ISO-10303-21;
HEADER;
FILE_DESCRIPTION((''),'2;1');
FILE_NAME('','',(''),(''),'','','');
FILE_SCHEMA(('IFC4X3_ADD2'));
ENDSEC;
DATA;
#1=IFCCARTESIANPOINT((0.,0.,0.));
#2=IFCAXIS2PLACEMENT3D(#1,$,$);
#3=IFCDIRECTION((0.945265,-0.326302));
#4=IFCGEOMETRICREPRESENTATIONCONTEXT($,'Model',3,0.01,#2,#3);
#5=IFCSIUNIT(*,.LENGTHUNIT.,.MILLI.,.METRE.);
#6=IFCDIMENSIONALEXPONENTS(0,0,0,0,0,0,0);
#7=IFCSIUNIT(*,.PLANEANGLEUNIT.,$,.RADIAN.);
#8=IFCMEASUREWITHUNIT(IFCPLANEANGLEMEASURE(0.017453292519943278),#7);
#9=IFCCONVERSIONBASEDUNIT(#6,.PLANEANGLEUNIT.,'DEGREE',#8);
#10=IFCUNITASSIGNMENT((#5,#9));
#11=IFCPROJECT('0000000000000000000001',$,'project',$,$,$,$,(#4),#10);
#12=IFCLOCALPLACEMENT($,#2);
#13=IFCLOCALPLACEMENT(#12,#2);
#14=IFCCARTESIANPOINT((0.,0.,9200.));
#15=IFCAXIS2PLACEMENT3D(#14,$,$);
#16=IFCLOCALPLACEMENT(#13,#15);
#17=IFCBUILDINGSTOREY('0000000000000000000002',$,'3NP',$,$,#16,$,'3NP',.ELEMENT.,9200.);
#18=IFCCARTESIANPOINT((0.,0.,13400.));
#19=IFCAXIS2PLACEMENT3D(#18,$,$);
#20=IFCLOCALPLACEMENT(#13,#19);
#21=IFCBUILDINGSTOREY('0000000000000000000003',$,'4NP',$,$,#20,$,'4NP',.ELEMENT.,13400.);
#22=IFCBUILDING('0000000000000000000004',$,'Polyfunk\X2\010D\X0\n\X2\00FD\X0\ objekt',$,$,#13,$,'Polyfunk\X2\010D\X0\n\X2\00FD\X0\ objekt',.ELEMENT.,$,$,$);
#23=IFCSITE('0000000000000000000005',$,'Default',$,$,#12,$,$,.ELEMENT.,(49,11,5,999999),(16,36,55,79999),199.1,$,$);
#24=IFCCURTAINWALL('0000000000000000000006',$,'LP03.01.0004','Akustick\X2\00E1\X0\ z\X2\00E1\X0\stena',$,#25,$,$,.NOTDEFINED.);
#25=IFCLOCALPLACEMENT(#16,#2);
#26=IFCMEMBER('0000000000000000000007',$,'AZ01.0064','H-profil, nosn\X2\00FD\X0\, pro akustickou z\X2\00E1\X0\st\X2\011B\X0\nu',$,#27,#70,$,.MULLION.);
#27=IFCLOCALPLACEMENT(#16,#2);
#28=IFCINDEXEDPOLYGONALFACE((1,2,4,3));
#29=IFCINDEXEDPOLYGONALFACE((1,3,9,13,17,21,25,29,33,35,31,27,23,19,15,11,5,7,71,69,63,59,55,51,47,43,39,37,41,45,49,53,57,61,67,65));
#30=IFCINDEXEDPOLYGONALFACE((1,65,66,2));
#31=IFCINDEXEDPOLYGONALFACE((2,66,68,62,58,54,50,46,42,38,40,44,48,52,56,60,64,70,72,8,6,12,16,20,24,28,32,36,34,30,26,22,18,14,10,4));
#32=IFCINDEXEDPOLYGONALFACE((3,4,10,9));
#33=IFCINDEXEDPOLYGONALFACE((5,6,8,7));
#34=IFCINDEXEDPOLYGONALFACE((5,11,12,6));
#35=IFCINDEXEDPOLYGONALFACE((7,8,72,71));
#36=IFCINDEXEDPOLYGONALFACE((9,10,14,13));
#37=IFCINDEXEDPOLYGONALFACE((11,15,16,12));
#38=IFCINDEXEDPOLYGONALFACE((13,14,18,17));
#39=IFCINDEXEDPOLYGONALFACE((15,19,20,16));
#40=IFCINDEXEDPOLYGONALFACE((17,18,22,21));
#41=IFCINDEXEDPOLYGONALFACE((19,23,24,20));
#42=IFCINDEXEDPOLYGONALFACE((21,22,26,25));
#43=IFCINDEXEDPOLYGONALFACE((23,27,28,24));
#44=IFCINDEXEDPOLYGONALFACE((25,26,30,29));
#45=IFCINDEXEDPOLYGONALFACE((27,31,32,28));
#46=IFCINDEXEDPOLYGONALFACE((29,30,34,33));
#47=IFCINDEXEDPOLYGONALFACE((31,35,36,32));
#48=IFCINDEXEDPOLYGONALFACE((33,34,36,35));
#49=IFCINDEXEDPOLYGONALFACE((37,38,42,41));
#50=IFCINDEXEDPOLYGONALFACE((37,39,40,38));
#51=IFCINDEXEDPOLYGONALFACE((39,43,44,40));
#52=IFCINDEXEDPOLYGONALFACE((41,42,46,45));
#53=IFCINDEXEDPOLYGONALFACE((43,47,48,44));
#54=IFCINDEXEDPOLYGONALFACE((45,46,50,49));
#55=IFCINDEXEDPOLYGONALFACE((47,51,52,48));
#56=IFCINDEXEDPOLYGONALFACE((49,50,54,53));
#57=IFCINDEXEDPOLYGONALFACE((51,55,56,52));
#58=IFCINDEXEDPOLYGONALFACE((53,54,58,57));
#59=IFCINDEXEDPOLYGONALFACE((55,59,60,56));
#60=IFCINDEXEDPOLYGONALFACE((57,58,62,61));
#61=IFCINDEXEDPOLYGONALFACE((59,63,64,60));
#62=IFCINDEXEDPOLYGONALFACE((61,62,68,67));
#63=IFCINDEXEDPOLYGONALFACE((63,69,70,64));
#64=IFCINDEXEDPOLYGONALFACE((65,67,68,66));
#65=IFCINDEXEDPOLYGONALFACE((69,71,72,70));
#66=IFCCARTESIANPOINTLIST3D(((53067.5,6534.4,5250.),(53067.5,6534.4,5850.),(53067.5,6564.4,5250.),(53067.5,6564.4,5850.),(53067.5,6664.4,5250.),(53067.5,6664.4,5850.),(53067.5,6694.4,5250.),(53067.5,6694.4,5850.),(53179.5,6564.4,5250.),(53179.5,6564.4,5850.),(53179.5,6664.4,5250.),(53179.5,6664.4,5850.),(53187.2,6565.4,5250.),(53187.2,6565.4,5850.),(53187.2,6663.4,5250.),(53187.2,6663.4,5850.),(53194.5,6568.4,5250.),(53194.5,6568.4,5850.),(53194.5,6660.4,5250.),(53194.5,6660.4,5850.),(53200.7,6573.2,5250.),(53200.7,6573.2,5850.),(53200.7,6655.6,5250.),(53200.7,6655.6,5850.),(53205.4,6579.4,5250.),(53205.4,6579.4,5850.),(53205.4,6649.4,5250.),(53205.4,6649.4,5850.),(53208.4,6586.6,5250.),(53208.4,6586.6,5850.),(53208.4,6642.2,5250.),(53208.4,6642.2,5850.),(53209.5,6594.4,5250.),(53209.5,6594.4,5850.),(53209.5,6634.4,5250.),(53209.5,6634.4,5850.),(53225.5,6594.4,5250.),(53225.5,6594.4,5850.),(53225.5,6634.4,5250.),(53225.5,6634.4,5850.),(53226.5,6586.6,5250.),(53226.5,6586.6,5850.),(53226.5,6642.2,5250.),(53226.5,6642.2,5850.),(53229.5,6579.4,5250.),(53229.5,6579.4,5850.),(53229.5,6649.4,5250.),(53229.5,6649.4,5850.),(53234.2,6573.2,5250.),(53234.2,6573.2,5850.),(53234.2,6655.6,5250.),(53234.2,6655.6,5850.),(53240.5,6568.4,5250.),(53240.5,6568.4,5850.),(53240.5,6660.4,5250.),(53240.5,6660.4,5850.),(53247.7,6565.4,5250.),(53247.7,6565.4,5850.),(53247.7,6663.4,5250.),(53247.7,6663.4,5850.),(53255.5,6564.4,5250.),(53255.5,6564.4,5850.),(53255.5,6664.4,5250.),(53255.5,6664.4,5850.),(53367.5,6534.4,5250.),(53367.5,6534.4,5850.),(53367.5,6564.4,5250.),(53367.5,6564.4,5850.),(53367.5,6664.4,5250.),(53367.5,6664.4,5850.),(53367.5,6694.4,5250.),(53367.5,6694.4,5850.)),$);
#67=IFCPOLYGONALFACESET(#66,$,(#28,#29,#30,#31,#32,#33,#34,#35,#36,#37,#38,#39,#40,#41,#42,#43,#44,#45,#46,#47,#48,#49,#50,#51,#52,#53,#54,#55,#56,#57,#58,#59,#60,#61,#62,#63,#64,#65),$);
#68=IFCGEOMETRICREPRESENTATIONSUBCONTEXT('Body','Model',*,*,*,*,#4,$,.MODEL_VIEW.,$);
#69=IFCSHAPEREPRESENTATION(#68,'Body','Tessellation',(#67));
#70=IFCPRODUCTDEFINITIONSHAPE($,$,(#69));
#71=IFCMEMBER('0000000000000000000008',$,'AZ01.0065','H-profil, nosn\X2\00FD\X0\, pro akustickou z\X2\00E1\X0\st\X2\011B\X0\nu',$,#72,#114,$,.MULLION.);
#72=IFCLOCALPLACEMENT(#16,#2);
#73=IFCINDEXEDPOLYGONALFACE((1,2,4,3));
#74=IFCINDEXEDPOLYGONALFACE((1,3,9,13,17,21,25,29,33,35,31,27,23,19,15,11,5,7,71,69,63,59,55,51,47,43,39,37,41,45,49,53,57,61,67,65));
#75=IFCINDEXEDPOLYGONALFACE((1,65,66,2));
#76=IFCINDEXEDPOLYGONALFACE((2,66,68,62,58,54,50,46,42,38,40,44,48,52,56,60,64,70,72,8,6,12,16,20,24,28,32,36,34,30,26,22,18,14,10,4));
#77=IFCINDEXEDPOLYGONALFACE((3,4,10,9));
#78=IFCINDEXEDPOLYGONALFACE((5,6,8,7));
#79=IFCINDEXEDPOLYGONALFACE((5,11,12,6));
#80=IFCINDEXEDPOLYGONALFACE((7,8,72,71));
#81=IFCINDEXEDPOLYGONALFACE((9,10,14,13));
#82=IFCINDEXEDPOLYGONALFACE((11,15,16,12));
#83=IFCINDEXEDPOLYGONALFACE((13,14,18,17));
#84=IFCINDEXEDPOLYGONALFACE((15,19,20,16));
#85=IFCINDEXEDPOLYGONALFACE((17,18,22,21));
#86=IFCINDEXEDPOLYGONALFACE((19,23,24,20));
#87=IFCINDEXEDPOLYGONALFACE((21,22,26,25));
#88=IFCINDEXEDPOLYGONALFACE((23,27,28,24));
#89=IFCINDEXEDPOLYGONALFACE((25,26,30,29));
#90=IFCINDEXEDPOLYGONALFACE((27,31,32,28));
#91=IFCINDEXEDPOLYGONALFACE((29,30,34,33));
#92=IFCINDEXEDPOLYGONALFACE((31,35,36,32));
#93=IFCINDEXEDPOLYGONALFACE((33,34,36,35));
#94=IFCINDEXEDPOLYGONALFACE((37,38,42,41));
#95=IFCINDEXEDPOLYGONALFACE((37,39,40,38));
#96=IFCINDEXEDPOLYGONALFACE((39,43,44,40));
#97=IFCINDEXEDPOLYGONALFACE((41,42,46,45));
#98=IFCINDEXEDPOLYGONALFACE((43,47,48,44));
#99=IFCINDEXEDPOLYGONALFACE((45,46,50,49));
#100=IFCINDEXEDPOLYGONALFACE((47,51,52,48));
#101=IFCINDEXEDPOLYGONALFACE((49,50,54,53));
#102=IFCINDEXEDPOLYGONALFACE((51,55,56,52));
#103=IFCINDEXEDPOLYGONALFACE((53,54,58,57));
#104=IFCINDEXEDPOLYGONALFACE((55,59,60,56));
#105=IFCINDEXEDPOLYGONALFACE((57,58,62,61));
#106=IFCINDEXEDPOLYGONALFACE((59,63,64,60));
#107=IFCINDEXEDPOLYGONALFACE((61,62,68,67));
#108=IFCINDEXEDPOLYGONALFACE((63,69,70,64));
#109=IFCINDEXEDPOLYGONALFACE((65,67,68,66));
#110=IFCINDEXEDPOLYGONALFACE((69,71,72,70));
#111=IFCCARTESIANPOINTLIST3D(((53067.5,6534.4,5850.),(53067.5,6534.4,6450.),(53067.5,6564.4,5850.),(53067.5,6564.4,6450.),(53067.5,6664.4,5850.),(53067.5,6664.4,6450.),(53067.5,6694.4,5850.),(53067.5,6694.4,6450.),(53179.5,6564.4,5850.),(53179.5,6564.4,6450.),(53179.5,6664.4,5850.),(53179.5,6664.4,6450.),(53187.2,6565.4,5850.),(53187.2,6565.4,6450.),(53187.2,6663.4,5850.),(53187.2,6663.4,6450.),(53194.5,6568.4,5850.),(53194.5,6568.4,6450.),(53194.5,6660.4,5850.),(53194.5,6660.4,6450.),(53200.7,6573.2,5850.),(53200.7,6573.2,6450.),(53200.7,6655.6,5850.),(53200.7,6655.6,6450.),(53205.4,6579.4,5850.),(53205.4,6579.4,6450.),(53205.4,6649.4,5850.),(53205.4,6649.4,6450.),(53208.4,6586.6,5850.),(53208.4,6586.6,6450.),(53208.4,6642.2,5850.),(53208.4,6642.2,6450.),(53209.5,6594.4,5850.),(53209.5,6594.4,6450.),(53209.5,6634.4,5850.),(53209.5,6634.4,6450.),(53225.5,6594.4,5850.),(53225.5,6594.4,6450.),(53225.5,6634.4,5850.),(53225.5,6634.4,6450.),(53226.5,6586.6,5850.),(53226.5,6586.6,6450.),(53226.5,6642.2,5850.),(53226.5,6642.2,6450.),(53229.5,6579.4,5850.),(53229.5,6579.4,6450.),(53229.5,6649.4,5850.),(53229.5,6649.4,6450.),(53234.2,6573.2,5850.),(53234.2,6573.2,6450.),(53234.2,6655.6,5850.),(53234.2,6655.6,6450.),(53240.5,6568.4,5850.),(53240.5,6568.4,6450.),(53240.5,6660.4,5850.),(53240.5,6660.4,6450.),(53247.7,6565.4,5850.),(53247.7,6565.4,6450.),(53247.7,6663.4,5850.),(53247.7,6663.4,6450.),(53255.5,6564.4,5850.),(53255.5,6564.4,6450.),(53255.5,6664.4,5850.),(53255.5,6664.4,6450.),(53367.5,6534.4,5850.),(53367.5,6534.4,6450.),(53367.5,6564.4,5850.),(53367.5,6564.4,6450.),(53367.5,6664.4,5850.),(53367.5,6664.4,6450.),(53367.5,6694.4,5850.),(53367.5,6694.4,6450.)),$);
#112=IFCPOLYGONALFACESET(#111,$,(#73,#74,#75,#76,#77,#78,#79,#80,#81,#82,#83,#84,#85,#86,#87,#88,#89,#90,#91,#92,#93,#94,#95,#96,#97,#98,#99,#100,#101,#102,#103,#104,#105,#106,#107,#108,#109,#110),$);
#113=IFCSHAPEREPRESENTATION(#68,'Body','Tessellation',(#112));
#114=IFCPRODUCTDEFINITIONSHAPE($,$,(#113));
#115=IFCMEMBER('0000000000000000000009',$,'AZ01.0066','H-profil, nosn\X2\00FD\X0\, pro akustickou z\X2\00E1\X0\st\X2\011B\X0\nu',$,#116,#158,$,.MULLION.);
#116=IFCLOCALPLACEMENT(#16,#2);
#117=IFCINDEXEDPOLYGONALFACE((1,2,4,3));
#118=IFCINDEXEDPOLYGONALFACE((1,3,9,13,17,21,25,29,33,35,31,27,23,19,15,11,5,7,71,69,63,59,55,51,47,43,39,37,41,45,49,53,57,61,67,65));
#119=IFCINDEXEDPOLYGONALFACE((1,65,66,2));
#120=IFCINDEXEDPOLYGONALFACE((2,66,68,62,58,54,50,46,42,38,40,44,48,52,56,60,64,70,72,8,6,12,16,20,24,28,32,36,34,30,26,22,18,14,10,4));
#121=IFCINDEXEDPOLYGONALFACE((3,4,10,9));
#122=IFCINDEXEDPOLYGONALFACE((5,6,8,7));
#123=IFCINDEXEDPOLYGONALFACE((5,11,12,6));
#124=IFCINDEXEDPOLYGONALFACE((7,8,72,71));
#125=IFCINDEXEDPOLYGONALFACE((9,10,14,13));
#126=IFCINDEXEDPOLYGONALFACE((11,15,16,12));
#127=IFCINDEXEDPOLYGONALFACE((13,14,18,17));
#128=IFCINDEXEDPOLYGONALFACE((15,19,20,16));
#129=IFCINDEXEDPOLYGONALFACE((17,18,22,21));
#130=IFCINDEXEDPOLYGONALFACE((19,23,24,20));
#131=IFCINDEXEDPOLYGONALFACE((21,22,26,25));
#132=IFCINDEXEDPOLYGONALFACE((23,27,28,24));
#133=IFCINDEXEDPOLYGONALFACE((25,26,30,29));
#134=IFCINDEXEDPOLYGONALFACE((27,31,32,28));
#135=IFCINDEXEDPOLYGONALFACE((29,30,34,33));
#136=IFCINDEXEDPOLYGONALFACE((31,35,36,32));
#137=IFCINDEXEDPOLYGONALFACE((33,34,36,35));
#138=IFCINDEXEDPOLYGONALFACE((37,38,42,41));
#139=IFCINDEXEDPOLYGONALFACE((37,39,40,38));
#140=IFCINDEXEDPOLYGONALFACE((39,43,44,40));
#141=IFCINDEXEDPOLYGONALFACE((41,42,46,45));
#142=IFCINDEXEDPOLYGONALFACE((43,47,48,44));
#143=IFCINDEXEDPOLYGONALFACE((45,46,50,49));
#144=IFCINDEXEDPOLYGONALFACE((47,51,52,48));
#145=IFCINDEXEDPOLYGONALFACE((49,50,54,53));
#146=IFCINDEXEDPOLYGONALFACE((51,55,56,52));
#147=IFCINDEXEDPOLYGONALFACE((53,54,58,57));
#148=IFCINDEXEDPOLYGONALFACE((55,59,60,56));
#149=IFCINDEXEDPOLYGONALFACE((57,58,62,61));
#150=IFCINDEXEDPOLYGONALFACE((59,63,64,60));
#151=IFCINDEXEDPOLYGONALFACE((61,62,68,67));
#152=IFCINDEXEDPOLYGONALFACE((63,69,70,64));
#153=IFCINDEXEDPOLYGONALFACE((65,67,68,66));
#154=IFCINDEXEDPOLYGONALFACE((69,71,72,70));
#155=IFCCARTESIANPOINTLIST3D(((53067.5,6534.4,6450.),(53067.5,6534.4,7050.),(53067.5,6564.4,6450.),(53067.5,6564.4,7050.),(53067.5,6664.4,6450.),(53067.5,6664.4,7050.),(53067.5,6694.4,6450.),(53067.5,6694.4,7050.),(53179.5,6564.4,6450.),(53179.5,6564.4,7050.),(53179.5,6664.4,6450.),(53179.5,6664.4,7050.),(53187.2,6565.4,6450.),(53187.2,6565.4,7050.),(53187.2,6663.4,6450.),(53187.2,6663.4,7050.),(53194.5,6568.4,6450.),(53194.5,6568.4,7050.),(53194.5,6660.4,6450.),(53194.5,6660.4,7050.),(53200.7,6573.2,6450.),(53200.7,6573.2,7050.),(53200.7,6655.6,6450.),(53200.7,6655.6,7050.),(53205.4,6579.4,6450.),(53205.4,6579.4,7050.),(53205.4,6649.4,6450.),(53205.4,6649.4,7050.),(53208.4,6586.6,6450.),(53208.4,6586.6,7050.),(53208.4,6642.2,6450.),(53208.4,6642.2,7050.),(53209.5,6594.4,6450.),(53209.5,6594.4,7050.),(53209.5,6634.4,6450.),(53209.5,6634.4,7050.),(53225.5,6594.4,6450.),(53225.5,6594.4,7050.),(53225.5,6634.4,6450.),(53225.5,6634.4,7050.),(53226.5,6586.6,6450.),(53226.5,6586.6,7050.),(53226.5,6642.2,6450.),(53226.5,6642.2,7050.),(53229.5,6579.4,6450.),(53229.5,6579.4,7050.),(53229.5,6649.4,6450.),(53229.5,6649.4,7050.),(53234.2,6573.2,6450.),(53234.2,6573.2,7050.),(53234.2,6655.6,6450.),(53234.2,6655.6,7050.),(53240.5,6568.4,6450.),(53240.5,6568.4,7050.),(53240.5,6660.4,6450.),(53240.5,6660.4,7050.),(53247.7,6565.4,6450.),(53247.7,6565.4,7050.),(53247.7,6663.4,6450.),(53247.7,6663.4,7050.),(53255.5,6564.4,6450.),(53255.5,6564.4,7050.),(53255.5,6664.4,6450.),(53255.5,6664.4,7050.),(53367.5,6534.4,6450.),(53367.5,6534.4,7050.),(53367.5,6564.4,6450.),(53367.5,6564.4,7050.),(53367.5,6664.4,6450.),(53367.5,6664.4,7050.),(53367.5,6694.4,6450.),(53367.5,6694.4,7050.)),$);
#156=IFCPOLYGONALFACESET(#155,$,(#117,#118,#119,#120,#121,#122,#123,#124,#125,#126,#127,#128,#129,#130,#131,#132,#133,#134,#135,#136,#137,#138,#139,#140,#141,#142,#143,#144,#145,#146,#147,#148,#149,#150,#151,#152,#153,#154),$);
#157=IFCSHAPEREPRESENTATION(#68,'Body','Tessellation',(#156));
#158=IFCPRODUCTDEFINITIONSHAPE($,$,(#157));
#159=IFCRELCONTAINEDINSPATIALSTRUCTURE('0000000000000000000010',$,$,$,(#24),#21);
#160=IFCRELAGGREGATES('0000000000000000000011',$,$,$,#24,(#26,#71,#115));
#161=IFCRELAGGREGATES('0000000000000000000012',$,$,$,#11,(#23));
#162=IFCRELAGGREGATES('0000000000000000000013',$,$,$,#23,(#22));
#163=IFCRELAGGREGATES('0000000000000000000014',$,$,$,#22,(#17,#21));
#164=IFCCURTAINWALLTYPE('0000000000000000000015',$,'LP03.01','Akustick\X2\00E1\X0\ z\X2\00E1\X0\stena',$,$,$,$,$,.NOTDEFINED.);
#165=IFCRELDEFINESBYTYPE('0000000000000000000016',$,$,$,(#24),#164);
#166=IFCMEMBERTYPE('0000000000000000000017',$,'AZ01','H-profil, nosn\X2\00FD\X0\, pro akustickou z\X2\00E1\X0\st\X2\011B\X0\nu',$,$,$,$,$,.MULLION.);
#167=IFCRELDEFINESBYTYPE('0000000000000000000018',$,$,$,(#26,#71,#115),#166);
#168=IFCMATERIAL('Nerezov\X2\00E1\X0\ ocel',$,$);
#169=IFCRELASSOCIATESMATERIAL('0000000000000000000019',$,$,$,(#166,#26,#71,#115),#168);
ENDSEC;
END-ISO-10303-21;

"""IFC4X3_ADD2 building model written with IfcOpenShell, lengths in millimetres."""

from ifc_helpers import new_model, entity, si_unit, converted_unit, direction, frame, frame_2d, origin, place, context, subcontext, project, spatial, polyline, circle_curve, parameter, trimmed, segment, composite_curve, outline, extrude, source, transform, mapped, material, material_profile, profile_set, profile_usage, type_object, element, aggregate, save


model = new_model("IFC4X3_ADD2")

# Units and contexts
model_context = context("Model", 3, precision=0.01, world=origin(), true_north=direction((0.945265, -0.326302)))
body_context = subcontext(model_context, "Body", "Model", "MODEL_VIEW")
ifc_project = project(units=[si_unit("LENGTHUNIT", "METRE", prefix="MILLI"), converted_unit("PLANEANGLEUNIT", "DEGREE", entity("IfcPlaneAngleMeasure", 0.017453292519943278), si_unit("PLANEANGLEUNIT", "RADIAN"), dimensions=[0, 0, 0, 0, 0, 0, 0])], contexts=[model_context])

# Site, building, storey
site_placement = place(None, origin())
site = spatial("IfcSite", under=ifc_project, at=site_placement, Name="Default", CompositionType="ELEMENT", RefLatitude=(49, 11, 5, 999999), RefLongitude=(16, 36, 55, 79999), RefElevation=199.1)
building_placement = place(site_placement, origin())
building = spatial("IfcBuilding", under=site, at=building_placement, Name="Polyfunkčný objekt", LongName="Polyfunkčný objekt", CompositionType="ELEMENT")
storey_1_placement = place(building_placement, frame((0.0, 0.0, 9200.0)))
storey_1 = spatial("IfcBuildingStorey", under=building, at=storey_1_placement, Name="3NP", LongName="3NP", CompositionType="ELEMENT", Elevation=9200.0)

# Shared definitions
storey_2_placement = place(building_placement, frame((0.0, 0.0, 13400.0)))
storey_2 = spatial("IfcBuildingStorey", under=building, at=storey_2_placement, Name="4NP", LongName="4NP", CompositionType="ELEMENT", Elevation=13400.0)

# Curtain wall, members
curtain_wall_type_1 = type_object("IfcCurtainWallType", Name="LP03.01", Description="Akustická zástena", PredefinedType="NOTDEFINED")
curtain_wall_1_placement = place(storey_2_placement, frame((0.0, 0.0, -13400.0)))
curtain_wall_1 = element("IfcCurtainWall", 1, at=curtain_wall_1_placement, inside=storey_2, type_object=curtain_wall_type_1, Name="LP03.01.0004", Description="Akustická zástena", PredefinedType="NOTDEFINED")
ifc_material_1 = material(Name="Nerezová ocel")
ifc_material_profile_1 = material_profile(ifc_material_1, outline(composite_curve([segment(polyline([(50.0, -150.0), (80.0, -150.0)]), True, "CONTINUOUS"), segment(polyline([(80.0, -150.0), (80.0, 150.0)]), True, "CONTINUOUS"), segment(polyline([(80.0, 150.0), (50.0, 150.0)]), True, "CONTINUOUS"), segment(polyline([(50.0, 150.0), (50.0, 38.0)]), True, "CONTINUOUS"), segment(trimmed(circle_curve(frame_2d((20.0, 38.0), x_axis=(0.0, 1.0)), 30.0), [parameter(180.0)], [parameter(270.0)], True, "PARAMETER"), False, "CONTINUOUS"), segment(polyline([(20.0, 8.0), (-20.0, 8.0)]), True, "CONTINUOUS"), segment(trimmed(circle_curve(frame_2d((-20.0, 38.0), x_axis=(0.0, 1.0)), 30.0), [parameter(90.0)], [parameter(180.0)], True, "PARAMETER"), False, "CONTINUOUS"), segment(polyline([(-50.0, 38.0), (-50.0, 150.0)]), True, "CONTINUOUS"), segment(polyline([(-50.0, 150.0), (-80.0, 150.0)]), True, "CONTINUOUS"), segment(polyline([(-80.0, 150.0), (-80.0, -150.0)]), True, "CONTINUOUS"), segment(polyline([(-80.0, -150.0), (-50.0, -150.0)]), True, "CONTINUOUS"), segment(polyline([(-50.0, -150.0), (-50.0, -38.0)]), True, "CONTINUOUS"), segment(trimmed(circle_curve(frame_2d((-20.0, -38.0), x_axis=(0.0, 1.0)), 30.0), [parameter(0.0)], [parameter(90.0)], True, "PARAMETER"), False, "CONTINUOUS"), segment(polyline([(-20.0, -8.0), (20.0, -8.0)]), True, "CONTINUOUS"), segment(trimmed(circle_curve(frame_2d((20.0, -38.0), x_axis=(0.0, 1.0)), 30.0), [parameter(270.0)], [parameter(0.0)], True, "PARAMETER"), False, "CONTINUOUS"), segment(polyline([(50.0, -38.0), (50.0, -150.0)]), True, "CONTINUOUS")], self_intersect=False)), Name="Profil zástena")
ifc_profile_set_1 = profile_set([ifc_material_profile_1], Name="Profil zástena")
ifc_profile_usage_1 = profile_usage(ifc_profile_set_1)
member_type_1 = type_object("IfcMemberType", Name="AZ01", Description="H-profil, nosný, pro akustickou zástěnu", PredefinedType="MULLION", material=ifc_profile_set_1)
shared_shape_1 = source(origin(), body_context, "Body", "SweptSolid", [
    extrude(outline(composite_curve([segment(polyline([(50.0, -150.0), (80.0, -150.0)]), True, "CONTINUOUS"), segment(polyline([(80.0, -150.0), (80.0, 150.0)]), True, "CONTINUOUS"), segment(polyline([(80.0, 150.0), (50.0, 150.0)]), True, "CONTINUOUS"), segment(polyline([(50.0, 150.0), (50.0, 38.0)]), True, "CONTINUOUS"), segment(trimmed(circle_curve(frame_2d((20.0, 38.0), x_axis=(0.0, 1.0)), 30.0), [parameter(180.0)], [parameter(270.0)], True, "PARAMETER"), False, "CONTINUOUS"), segment(polyline([(20.0, 8.0), (-20.0, 8.0)]), True, "CONTINUOUS"), segment(trimmed(circle_curve(frame_2d((-20.0, 38.0), x_axis=(0.0, 1.0)), 30.0), [parameter(90.0)], [parameter(180.0)], True, "PARAMETER"), False, "CONTINUOUS"), segment(polyline([(-50.0, 38.0), (-50.0, 150.0)]), True, "CONTINUOUS"), segment(polyline([(-50.0, 150.0), (-80.0, 150.0)]), True, "CONTINUOUS"), segment(polyline([(-80.0, 150.0), (-80.0, -150.0)]), True, "CONTINUOUS"), segment(polyline([(-80.0, -150.0), (-50.0, -150.0)]), True, "CONTINUOUS"), segment(polyline([(-50.0, -150.0), (-50.0, -38.0)]), True, "CONTINUOUS"), segment(trimmed(circle_curve(frame_2d((-20.0, -38.0), x_axis=(0.0, 1.0)), 30.0), [parameter(0.0)], [parameter(90.0)], True, "PARAMETER"), False, "CONTINUOUS"), segment(polyline([(-20.0, -8.0), (20.0, -8.0)]), True, "CONTINUOUS"), segment(trimmed(circle_curve(frame_2d((20.0, -38.0), x_axis=(0.0, 1.0)), 30.0), [parameter(270.0)], [parameter(0.0)], True, "PARAMETER"), False, "CONTINUOUS"), segment(polyline([(50.0, -38.0), (50.0, -150.0)]), True, "CONTINUOUS")], self_intersect=False)), frame((0.0, 0.0, -600.0), z_axis=(0.0, 0.0, 1.0), x_axis=(0.0, -1.0, 0.0)), (0.0, 0.0, 1.0), 600.0),
])
member_1_placement = place(curtain_wall_1_placement, frame((53217.5, 6614.4, 14450.0), z_axis=(0.0, 0.0, -1.0), x_axis=(1.0, 0.0, 0.0)))
member_1 = element("IfcMember", 2, at=member_1_placement, type_object=member_type_1, material=ifc_profile_usage_1, Name="AZ01.0064", Description="H-profil, nosný, pro akustickou zástěnu", PredefinedType="MULLION", context=body_context, shape_type="MappedRepresentation", body=[
    mapped(shared_shape_1, transform((0.0, 0.0, 0.0), scale=1.0)),
])
member_2_placement = place(curtain_wall_1_placement, frame((53217.5, 6614.4, 15050.0), z_axis=(0.0, 0.0, -1.0), x_axis=(1.0, 0.0, 0.0)))
member_2 = element("IfcMember", 3, at=member_2_placement, type_object=member_type_1, material=ifc_profile_usage_1, Name="AZ01.0065", Description="H-profil, nosný, pro akustickou zástěnu", PredefinedType="MULLION", context=body_context, shape_type="MappedRepresentation", body=[
    mapped(shared_shape_1, transform((0.0, 0.0, 0.0), scale=1.0)),
])
member_3_placement = place(curtain_wall_1_placement, frame((53217.5, 6614.4, 15650.0), z_axis=(0.0, 0.0, -1.0), x_axis=(1.0, 0.0, 0.0)))
member_3 = element("IfcMember", 4, at=member_3_placement, type_object=member_type_1, material=ifc_profile_usage_1, Name="AZ01.0066", Description="H-profil, nosný, pro akustickou zástěnu", PredefinedType="MULLION", context=body_context, shape_type="MappedRepresentation", body=[
    mapped(shared_shape_1, transform((0.0, 0.0, 0.0), scale=1.0)),
])
aggregate(curtain_wall_1, [member_1, member_2, member_3])

save(model, "model.ifc")
